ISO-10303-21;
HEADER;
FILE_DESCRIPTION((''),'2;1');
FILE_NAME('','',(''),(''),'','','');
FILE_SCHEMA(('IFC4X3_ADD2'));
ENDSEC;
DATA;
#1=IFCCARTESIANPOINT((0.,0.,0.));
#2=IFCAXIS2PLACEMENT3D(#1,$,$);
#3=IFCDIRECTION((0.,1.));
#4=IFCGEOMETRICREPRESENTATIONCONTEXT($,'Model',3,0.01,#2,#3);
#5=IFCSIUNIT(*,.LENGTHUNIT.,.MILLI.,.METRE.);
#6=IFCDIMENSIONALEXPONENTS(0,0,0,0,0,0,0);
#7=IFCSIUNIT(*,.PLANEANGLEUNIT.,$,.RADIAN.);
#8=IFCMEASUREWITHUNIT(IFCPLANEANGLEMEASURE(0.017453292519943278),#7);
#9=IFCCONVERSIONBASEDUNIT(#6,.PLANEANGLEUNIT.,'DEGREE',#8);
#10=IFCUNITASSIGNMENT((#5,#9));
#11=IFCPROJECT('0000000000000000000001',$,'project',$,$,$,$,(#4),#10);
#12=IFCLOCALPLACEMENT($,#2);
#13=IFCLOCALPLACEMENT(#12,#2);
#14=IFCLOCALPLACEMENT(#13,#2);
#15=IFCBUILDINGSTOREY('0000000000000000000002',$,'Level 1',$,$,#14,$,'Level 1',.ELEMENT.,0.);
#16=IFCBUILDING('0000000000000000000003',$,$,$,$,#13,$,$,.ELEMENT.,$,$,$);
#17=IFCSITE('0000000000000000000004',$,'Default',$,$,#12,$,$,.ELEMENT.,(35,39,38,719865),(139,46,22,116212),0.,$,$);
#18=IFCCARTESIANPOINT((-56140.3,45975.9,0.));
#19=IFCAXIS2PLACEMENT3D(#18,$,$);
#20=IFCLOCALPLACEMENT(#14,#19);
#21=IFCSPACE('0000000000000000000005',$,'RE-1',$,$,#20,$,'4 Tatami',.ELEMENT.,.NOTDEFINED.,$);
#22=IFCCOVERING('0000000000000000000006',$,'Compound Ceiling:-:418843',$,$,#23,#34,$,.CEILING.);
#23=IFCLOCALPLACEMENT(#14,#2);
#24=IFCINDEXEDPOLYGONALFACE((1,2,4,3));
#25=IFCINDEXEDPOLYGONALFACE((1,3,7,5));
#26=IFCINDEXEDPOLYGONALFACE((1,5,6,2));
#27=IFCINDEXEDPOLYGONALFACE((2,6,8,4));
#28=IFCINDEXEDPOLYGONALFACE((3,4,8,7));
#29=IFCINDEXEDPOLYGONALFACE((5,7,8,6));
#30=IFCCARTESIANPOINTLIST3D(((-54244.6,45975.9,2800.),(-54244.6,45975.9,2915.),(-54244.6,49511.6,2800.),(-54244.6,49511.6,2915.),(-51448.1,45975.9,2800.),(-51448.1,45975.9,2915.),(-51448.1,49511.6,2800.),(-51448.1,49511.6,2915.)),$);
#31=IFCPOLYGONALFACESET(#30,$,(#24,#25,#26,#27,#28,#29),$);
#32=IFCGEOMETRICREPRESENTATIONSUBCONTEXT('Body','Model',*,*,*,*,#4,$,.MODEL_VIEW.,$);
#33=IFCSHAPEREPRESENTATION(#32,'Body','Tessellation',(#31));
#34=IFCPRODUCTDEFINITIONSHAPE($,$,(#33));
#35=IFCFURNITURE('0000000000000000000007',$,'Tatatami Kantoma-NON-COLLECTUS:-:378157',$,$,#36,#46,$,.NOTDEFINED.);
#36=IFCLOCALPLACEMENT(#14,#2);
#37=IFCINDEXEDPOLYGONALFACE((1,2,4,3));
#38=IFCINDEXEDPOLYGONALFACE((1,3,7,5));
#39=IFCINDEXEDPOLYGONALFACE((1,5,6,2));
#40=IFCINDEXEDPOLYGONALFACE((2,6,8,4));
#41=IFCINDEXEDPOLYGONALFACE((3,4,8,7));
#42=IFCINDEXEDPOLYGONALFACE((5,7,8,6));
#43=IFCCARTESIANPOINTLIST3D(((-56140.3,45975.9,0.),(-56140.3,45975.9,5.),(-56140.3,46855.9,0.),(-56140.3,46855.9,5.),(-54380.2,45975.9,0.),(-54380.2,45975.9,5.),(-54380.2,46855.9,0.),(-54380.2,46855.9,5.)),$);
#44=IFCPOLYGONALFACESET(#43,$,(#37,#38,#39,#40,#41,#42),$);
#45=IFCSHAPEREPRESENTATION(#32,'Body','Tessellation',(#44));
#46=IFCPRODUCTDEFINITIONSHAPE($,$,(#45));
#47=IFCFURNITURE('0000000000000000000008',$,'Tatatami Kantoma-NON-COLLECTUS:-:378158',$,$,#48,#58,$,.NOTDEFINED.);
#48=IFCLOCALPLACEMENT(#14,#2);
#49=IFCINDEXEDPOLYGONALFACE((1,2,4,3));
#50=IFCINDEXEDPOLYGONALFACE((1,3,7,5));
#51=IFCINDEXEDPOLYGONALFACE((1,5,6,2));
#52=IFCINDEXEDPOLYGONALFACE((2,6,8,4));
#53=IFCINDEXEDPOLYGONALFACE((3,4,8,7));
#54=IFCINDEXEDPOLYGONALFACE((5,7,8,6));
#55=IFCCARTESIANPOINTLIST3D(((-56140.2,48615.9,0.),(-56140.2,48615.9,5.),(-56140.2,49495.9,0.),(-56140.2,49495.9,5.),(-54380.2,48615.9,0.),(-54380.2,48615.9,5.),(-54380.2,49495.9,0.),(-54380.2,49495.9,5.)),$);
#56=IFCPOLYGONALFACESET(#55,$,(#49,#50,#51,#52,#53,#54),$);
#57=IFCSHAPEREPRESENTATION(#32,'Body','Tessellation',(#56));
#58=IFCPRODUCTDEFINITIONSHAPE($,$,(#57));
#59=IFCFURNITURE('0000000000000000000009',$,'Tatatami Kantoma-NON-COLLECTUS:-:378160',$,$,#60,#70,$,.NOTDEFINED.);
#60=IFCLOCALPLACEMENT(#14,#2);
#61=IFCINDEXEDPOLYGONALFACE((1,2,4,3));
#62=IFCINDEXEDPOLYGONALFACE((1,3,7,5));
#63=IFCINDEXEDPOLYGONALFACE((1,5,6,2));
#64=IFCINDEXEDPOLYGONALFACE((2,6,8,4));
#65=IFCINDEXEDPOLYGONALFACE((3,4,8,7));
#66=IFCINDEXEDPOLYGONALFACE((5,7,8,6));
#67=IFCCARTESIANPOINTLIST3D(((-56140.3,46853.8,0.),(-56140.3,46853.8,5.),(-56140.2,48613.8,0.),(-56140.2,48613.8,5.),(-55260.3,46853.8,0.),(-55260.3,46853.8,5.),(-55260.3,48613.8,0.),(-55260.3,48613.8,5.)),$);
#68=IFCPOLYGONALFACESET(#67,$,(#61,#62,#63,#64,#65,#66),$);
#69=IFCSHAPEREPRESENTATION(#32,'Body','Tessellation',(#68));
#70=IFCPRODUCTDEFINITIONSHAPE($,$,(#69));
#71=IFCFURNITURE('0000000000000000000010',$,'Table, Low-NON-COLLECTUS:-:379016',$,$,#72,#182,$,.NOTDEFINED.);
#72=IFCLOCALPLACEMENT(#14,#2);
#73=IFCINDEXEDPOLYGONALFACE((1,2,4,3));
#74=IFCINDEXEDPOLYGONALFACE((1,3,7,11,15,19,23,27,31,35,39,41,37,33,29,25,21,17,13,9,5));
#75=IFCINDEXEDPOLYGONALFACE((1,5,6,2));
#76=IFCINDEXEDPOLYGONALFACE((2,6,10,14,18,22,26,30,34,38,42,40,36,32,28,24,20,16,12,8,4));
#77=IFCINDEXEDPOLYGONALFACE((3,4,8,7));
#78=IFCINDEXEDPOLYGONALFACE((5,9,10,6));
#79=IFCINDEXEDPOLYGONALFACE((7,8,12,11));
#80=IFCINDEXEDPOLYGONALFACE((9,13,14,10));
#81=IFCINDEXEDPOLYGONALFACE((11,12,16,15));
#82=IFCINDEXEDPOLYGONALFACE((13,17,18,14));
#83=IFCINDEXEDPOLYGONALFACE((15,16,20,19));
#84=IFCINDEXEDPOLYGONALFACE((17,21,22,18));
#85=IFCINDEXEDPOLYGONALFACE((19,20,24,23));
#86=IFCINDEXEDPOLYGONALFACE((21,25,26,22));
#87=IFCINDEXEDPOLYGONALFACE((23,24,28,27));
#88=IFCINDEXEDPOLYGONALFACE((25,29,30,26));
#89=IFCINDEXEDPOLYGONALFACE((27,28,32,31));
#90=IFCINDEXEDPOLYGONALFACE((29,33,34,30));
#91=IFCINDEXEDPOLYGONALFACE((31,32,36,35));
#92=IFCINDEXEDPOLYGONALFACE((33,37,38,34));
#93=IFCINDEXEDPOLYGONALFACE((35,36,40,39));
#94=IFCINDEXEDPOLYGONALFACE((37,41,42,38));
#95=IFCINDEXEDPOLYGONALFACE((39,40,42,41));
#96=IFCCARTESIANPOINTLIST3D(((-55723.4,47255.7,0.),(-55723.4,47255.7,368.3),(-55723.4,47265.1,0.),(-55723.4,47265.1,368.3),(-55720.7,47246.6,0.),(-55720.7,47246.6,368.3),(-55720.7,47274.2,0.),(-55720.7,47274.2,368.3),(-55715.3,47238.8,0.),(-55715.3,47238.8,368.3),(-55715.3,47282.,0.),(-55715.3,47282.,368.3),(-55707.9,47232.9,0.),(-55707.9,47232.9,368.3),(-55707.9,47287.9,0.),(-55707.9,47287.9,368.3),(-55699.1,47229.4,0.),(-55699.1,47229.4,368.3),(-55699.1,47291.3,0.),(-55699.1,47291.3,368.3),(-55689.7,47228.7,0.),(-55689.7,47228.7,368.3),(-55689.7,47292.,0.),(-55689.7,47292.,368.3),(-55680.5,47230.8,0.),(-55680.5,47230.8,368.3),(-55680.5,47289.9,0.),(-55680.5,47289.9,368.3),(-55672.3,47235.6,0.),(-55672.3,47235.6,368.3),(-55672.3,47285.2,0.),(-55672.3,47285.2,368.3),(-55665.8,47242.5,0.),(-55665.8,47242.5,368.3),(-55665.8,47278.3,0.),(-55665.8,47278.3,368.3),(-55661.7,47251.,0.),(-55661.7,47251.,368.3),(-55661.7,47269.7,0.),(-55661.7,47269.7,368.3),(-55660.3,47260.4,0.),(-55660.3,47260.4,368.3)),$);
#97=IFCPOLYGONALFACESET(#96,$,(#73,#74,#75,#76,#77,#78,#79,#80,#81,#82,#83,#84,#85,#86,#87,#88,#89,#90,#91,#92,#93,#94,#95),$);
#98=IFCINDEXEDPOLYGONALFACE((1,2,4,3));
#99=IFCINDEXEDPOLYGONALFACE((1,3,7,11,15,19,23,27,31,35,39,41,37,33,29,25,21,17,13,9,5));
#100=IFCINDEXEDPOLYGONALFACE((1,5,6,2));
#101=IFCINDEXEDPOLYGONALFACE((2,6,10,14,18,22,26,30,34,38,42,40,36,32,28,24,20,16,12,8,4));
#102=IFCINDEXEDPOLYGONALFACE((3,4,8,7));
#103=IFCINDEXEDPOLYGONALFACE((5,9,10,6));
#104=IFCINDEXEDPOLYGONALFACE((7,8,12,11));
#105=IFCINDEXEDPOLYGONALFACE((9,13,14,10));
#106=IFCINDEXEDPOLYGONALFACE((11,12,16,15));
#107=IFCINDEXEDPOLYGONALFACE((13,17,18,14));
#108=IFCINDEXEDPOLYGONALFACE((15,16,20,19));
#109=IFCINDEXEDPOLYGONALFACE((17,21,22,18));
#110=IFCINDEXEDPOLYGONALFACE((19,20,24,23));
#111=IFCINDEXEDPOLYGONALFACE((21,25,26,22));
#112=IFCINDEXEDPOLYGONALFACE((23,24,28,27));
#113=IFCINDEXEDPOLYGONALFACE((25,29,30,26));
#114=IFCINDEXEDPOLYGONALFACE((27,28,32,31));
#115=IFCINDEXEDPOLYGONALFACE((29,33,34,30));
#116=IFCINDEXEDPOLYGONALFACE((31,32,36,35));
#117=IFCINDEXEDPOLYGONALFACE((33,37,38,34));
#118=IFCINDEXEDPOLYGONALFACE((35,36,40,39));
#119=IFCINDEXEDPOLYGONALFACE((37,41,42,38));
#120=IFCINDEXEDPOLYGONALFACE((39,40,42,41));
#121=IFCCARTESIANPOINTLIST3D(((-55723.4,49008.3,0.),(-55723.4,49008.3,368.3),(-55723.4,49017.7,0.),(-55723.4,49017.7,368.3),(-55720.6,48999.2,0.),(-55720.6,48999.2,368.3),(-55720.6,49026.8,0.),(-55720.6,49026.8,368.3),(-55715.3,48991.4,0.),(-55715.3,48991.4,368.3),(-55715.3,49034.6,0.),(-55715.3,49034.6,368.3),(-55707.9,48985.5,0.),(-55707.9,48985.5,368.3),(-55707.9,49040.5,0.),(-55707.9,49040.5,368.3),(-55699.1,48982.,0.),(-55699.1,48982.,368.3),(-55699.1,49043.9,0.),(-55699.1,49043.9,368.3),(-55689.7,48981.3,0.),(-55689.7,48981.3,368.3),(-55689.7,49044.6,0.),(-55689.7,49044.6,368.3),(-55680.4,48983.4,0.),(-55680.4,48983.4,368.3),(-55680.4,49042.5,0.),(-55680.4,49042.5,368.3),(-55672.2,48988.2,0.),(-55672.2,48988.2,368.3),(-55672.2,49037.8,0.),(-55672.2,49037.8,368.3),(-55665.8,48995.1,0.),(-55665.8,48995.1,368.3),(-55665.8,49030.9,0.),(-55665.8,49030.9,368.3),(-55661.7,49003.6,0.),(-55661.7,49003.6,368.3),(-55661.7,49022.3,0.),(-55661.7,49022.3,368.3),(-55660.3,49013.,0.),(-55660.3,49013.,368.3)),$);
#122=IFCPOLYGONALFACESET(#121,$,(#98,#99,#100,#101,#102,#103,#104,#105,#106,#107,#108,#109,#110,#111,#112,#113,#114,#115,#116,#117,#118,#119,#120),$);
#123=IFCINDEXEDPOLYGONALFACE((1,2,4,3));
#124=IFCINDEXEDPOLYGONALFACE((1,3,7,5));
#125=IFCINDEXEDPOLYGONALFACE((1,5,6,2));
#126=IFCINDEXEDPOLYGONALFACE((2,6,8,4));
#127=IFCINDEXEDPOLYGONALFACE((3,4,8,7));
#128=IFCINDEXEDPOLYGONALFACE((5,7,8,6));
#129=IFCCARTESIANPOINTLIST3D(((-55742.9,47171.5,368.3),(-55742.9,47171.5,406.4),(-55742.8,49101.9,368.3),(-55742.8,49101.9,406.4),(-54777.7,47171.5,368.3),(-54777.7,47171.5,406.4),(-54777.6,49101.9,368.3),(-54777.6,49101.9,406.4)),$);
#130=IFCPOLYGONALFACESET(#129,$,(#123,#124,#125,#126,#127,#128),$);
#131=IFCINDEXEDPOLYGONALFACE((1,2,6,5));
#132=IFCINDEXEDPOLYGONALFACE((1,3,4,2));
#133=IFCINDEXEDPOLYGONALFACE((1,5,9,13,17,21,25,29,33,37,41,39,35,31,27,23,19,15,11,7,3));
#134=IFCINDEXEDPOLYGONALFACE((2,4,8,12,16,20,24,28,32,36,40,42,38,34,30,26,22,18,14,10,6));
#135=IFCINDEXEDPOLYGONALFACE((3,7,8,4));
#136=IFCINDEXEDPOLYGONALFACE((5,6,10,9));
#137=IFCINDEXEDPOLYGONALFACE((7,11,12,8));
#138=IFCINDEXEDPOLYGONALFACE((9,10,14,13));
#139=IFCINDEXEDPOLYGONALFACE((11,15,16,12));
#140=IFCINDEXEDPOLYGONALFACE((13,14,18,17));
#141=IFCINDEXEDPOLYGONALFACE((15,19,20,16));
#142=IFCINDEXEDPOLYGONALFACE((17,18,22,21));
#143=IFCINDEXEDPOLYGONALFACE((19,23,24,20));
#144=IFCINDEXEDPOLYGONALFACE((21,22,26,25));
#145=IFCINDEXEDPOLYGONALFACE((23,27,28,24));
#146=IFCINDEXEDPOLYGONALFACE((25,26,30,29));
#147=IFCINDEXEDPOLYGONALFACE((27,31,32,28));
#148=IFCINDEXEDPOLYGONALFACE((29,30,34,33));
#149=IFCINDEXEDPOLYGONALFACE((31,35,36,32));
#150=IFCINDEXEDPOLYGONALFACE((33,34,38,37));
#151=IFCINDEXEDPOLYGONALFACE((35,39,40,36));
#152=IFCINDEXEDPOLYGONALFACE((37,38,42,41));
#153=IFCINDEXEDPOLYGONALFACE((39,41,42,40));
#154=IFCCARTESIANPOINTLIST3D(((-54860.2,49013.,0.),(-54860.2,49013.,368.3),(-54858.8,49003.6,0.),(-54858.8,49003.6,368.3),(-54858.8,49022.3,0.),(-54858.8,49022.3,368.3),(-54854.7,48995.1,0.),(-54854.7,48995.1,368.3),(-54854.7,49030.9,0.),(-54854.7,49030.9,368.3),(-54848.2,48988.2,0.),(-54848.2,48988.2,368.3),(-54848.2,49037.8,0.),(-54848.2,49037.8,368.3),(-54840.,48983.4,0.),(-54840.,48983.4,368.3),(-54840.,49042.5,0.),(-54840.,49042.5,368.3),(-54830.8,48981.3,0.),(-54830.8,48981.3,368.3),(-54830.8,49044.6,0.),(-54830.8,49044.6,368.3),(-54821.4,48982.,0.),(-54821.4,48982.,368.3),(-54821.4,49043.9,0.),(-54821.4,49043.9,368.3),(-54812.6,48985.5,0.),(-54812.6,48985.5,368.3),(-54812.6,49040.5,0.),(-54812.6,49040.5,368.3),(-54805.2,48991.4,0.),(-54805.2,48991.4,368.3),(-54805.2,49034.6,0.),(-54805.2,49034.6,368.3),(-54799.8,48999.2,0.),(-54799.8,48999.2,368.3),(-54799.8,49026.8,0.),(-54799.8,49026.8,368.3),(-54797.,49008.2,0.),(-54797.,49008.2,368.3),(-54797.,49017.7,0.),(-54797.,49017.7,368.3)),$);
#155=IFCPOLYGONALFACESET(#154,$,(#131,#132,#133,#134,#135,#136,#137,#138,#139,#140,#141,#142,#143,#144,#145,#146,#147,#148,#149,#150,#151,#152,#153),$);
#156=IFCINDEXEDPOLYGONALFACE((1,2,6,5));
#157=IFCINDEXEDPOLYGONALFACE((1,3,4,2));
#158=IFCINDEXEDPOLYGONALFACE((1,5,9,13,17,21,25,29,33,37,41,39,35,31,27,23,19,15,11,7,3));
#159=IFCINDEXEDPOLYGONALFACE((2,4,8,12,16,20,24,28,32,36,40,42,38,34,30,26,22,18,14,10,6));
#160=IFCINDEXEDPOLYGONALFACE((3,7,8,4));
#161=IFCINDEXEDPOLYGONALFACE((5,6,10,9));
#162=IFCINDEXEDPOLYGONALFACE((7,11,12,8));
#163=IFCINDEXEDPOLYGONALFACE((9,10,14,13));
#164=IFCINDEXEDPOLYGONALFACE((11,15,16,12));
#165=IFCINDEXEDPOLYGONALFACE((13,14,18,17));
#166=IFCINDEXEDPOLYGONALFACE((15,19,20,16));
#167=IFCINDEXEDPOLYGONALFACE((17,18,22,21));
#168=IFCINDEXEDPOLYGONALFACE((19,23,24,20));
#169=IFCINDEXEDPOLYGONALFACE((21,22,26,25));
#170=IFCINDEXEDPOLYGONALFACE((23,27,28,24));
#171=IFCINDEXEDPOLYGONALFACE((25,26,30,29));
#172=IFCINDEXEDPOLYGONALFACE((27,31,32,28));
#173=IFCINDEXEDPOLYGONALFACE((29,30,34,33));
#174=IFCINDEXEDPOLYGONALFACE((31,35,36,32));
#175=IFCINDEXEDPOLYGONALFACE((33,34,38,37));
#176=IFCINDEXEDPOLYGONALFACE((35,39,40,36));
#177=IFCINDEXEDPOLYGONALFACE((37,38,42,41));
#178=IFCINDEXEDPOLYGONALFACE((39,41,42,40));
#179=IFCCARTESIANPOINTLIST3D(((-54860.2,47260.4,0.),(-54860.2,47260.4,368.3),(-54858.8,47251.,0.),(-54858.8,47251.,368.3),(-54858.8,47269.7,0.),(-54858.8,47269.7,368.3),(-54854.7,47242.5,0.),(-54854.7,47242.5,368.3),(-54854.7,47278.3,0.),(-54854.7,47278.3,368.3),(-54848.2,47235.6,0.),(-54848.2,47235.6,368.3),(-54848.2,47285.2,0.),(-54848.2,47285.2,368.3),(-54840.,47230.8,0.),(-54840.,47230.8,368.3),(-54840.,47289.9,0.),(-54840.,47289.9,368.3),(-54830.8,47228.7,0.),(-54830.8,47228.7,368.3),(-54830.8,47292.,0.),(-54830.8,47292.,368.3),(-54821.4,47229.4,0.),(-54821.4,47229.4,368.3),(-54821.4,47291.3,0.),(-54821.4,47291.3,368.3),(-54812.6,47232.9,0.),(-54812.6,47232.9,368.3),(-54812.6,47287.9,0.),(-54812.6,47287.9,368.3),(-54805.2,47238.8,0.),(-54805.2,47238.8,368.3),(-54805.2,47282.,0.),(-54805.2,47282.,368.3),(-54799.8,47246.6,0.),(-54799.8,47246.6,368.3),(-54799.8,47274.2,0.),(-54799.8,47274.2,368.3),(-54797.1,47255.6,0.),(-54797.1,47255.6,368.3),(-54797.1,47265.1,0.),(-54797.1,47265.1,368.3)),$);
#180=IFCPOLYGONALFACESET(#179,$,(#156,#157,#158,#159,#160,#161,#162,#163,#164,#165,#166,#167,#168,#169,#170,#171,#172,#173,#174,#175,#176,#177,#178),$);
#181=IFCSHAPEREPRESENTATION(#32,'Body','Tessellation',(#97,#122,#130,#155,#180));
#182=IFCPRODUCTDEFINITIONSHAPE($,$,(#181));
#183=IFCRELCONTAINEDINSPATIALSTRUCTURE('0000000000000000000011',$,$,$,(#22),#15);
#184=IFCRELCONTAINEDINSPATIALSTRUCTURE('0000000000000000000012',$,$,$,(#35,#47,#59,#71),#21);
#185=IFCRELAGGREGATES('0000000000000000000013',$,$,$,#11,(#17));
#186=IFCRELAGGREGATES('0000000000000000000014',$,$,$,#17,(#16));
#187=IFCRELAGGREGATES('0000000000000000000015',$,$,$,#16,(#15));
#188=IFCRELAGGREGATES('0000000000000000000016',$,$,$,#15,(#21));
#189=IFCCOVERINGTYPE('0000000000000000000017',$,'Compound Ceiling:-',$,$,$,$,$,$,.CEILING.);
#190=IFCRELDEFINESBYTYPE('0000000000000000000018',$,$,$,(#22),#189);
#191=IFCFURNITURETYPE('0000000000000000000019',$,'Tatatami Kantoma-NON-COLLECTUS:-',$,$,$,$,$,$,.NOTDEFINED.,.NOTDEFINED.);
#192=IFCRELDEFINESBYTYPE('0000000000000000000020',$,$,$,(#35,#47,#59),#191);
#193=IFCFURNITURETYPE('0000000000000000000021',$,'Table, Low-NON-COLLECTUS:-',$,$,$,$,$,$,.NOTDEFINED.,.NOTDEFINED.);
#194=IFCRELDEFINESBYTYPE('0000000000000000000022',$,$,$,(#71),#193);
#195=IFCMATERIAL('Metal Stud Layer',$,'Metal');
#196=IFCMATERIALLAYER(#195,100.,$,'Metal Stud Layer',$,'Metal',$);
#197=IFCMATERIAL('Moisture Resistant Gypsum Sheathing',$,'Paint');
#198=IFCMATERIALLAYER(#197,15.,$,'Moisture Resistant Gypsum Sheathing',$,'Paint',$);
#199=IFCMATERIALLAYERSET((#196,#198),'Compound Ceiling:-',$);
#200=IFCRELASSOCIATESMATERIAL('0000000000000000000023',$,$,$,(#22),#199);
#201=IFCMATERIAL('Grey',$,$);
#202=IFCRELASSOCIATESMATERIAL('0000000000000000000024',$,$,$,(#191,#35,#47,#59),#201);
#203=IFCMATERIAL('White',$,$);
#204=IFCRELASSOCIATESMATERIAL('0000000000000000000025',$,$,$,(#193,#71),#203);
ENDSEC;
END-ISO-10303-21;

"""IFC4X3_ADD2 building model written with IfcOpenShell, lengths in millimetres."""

from ifc_helpers import new_model, entity, si_unit, converted_unit, direction, frame, frame_2d, origin, origin_2d_with_axis, place, context, subcontext, project, spatial, rectangle, circle, extrude, source, transform, mapped, material, layer, layer_set, layer_usage, type_object, type_shapes, element, save


model = new_model("IFC4X3_ADD2")

# Units and contexts
model_context = context("Model", 3, precision=0.01, world=origin(), true_north=direction((0.0, 1.0)))
body_context = subcontext(model_context, "Body", "Model", "MODEL_VIEW")
ifc_project = project(units=[si_unit("LENGTHUNIT", "METRE", prefix="MILLI"), converted_unit("PLANEANGLEUNIT", "DEGREE", entity("IfcPlaneAngleMeasure", 0.017453292519943278), si_unit("PLANEANGLEUNIT", "RADIAN"), dimensions=[0, 0, 0, 0, 0, 0, 0])], contexts=[model_context])

# Site, building, storey
site_placement = place(None, origin())
site = spatial("IfcSite", under=ifc_project, at=site_placement, Name="Default", CompositionType="ELEMENT", RefLatitude=(35, 39, 38, 719865), RefLongitude=(139, 46, 22, 116212), RefElevation=0.0)
building_placement = place(site_placement, origin())
building = spatial("IfcBuilding", under=site, at=building_placement, CompositionType="ELEMENT")
storey_placement = place(building_placement, origin())
storey = spatial("IfcBuildingStorey", under=building, at=storey_placement, Name="Level 1", LongName="Level 1", CompositionType="ELEMENT", Elevation=0.0)

# Shared definitions
ifc_material_1 = material(Name="Metal Stud Layer", Category="Metal")

# Covering
ifc_layer_1 = layer(ifc_material_1, 100.0, Name="Metal Stud Layer", Category="Metal")
ifc_material_2 = material(Name="Moisture Resistant Gypsum Sheathing", Category="Paint")
ifc_layer_2 = layer(ifc_material_2, 15.0, Name="Moisture Resistant Gypsum Sheathing", Category="Paint")
ifc_layer_set_1 = layer_set([ifc_layer_1, ifc_layer_2], Name="Compound Ceiling:-")
covering_type = type_object("IfcCoveringType", Name="Compound Ceiling:-", PredefinedType="CEILING")
ifc_layer_usage_1 = layer_usage(ifc_layer_set_1, "AXIS3", "NEGATIVE", 0.0)
covering_1_placement = place(storey_placement, frame((-54244.6, 45975.9, 2800.0)))
element("IfcCovering", 1, at=covering_1_placement, inside=storey, type_object=covering_type, material=ifc_layer_usage_1, Name="Compound Ceiling:-:418843", PredefinedType="CEILING", context=body_context, shape_type="SweptSolid", body=[
    extrude(rectangle(XDim=2796.4, YDim=3535.6, at=frame_2d((0.0, 0.0), x_axis=(1.0, 0.0))), frame((1398.2, 1767.8, 0.0)), (0.0, 0.0, 1.0), 115.0),
])

# Shared definitions
ifc_material_3 = material(Name="White")

# Shared definitions
space_1_placement = place(storey_placement, frame((-56140.3, 45975.9, 0.0)))
space_1 = spatial("IfcSpace", under=storey, at=space_1_placement, Name="RE-1", LongName="4 Tatami", CompositionType="ELEMENT", PredefinedType="NOTDEFINED")

# Furniture
ifc_material_4 = material(Name="Grey")
furniture_type_1 = type_object("IfcFurnitureType", Name="Tatatami Kantoma-NON-COLLECTUS:-", AssemblyPlace="NOTDEFINED", PredefinedType="NOTDEFINED", material=ifc_material_4)
shared_shape_1 = source(origin(), body_context, "Body", "SweptSolid", [
    extrude(rectangle(XDim=1760.0, YDim=880.0, at=origin_2d_with_axis()), frame((880.0, 440.0, 0.0), z_axis=(0.0, 0.0, 1.0), x_axis=(-1.0, 0.0, 0.0)), (0.0, 0.0, 1.0), 5.0),
])
type_shapes(furniture_type_1, [shared_shape_1])
for number, where, name in (
    (2, (0.0, 0.0, 0.0), "Tatatami Kantoma-NON-COLLECTUS:-:378157"),
    (3, (0.0, 2640.0, 0.0), "Tatatami Kantoma-NON-COLLECTUS:-:378158"),
):
    element("IfcFurniture", number, at=place(space_1_placement, frame(where)), inside=space_1, type_object=furniture_type_1, material=ifc_material_4, Name=name, PredefinedType="NOTDEFINED", context=body_context, shape_type="MappedRepresentation", body=[
        mapped(shared_shape_1, transform((0.0, 0.0, 0.0), scale=1.0)),
    ])
for number, where, z_axis, x_axis, name in (
    (4, (0.0, 2637.9, 0.0), (0.0, 0.0, 1.0), (-0.000004, -1.0, 0.0), "Tatatami Kantoma-NON-COLLECTUS:-:378160"),
):
    element("IfcFurniture", number, at=place(space_1_placement, frame(where, z_axis=z_axis, x_axis=x_axis)), inside=space_1, type_object=furniture_type_1, material=ifc_material_4, Name=name, PredefinedType="NOTDEFINED", context=body_context, shape_type="MappedRepresentation", body=[
        mapped(shared_shape_1, transform((0.0, 0.0, 0.0), scale=1.0)),
    ])
furniture_type_2 = type_object("IfcFurnitureType", Name="Table, Low-NON-COLLECTUS:-", AssemblyPlace="NOTDEFINED", PredefinedType="NOTDEFINED", material=ifc_material_3)
shared_shape_2 = source(origin(), body_context, "Body", "SweptSolid", [
    extrude(circle(Radius=31.8, at=frame_2d((0.0, 0.0), x_axis=(1.0, 0.0))), frame((876.3, -431.8, 0.0), z_axis=(0.0, 0.0, 1.0), x_axis=(0.0, 1.0, 0.0)), (0.0, 0.0, 1.0), 368.3),
    extrude(circle(Radius=31.8, at=origin_2d_with_axis()), frame((-876.3, -431.8, 0.0), z_axis=(0.0, 0.0, 1.0), x_axis=(0.0, 1.0, 0.0)), (0.0, 0.0, 1.0), 368.3),
    extrude(rectangle(XDim=1930.4, YDim=965.2, at=origin_2d_with_axis()), frame((0.0, 0.0, 368.3), z_axis=(0.0, 0.0, 1.0), x_axis=(-1.0, 0.0, 0.0)), (0.0, 0.0, 1.0), 38.1),
    extrude(circle(Radius=31.8, at=origin_2d_with_axis()), frame((-876.3, 431.8, 0.0), z_axis=(0.0, 0.0, 1.0), x_axis=(0.0, -1.0, 0.0)), (0.0, 0.0, 1.0), 368.3),
    extrude(circle(Radius=31.8, at=frame_2d((0.0, 0.0), x_axis=(1.0, 0.0))), frame((876.3, 431.8, 0.0), z_axis=(0.0, 0.0, 1.0), x_axis=(0.0, -1.0, 0.0)), (0.0, 0.0, 1.0), 368.3),
])
type_shapes(furniture_type_2, [shared_shape_2])
furniture_1_placement = place(space_1_placement, frame((880.0, 2160.8, 0.0), z_axis=(0.0, 0.0, 1.0), x_axis=(-0.000004, -1.0, 0.0)))
element("IfcFurniture", 5, at=furniture_1_placement, inside=space_1, type_object=furniture_type_2, material=ifc_material_3, Name="Table, Low-NON-COLLECTUS:-:379016", PredefinedType="NOTDEFINED", context=body_context, shape_type="MappedRepresentation", body=[
    mapped(shared_shape_2, transform((0.0, 0.0, 0.0), scale=1.0)),
])

save(model, "model.ifc")
